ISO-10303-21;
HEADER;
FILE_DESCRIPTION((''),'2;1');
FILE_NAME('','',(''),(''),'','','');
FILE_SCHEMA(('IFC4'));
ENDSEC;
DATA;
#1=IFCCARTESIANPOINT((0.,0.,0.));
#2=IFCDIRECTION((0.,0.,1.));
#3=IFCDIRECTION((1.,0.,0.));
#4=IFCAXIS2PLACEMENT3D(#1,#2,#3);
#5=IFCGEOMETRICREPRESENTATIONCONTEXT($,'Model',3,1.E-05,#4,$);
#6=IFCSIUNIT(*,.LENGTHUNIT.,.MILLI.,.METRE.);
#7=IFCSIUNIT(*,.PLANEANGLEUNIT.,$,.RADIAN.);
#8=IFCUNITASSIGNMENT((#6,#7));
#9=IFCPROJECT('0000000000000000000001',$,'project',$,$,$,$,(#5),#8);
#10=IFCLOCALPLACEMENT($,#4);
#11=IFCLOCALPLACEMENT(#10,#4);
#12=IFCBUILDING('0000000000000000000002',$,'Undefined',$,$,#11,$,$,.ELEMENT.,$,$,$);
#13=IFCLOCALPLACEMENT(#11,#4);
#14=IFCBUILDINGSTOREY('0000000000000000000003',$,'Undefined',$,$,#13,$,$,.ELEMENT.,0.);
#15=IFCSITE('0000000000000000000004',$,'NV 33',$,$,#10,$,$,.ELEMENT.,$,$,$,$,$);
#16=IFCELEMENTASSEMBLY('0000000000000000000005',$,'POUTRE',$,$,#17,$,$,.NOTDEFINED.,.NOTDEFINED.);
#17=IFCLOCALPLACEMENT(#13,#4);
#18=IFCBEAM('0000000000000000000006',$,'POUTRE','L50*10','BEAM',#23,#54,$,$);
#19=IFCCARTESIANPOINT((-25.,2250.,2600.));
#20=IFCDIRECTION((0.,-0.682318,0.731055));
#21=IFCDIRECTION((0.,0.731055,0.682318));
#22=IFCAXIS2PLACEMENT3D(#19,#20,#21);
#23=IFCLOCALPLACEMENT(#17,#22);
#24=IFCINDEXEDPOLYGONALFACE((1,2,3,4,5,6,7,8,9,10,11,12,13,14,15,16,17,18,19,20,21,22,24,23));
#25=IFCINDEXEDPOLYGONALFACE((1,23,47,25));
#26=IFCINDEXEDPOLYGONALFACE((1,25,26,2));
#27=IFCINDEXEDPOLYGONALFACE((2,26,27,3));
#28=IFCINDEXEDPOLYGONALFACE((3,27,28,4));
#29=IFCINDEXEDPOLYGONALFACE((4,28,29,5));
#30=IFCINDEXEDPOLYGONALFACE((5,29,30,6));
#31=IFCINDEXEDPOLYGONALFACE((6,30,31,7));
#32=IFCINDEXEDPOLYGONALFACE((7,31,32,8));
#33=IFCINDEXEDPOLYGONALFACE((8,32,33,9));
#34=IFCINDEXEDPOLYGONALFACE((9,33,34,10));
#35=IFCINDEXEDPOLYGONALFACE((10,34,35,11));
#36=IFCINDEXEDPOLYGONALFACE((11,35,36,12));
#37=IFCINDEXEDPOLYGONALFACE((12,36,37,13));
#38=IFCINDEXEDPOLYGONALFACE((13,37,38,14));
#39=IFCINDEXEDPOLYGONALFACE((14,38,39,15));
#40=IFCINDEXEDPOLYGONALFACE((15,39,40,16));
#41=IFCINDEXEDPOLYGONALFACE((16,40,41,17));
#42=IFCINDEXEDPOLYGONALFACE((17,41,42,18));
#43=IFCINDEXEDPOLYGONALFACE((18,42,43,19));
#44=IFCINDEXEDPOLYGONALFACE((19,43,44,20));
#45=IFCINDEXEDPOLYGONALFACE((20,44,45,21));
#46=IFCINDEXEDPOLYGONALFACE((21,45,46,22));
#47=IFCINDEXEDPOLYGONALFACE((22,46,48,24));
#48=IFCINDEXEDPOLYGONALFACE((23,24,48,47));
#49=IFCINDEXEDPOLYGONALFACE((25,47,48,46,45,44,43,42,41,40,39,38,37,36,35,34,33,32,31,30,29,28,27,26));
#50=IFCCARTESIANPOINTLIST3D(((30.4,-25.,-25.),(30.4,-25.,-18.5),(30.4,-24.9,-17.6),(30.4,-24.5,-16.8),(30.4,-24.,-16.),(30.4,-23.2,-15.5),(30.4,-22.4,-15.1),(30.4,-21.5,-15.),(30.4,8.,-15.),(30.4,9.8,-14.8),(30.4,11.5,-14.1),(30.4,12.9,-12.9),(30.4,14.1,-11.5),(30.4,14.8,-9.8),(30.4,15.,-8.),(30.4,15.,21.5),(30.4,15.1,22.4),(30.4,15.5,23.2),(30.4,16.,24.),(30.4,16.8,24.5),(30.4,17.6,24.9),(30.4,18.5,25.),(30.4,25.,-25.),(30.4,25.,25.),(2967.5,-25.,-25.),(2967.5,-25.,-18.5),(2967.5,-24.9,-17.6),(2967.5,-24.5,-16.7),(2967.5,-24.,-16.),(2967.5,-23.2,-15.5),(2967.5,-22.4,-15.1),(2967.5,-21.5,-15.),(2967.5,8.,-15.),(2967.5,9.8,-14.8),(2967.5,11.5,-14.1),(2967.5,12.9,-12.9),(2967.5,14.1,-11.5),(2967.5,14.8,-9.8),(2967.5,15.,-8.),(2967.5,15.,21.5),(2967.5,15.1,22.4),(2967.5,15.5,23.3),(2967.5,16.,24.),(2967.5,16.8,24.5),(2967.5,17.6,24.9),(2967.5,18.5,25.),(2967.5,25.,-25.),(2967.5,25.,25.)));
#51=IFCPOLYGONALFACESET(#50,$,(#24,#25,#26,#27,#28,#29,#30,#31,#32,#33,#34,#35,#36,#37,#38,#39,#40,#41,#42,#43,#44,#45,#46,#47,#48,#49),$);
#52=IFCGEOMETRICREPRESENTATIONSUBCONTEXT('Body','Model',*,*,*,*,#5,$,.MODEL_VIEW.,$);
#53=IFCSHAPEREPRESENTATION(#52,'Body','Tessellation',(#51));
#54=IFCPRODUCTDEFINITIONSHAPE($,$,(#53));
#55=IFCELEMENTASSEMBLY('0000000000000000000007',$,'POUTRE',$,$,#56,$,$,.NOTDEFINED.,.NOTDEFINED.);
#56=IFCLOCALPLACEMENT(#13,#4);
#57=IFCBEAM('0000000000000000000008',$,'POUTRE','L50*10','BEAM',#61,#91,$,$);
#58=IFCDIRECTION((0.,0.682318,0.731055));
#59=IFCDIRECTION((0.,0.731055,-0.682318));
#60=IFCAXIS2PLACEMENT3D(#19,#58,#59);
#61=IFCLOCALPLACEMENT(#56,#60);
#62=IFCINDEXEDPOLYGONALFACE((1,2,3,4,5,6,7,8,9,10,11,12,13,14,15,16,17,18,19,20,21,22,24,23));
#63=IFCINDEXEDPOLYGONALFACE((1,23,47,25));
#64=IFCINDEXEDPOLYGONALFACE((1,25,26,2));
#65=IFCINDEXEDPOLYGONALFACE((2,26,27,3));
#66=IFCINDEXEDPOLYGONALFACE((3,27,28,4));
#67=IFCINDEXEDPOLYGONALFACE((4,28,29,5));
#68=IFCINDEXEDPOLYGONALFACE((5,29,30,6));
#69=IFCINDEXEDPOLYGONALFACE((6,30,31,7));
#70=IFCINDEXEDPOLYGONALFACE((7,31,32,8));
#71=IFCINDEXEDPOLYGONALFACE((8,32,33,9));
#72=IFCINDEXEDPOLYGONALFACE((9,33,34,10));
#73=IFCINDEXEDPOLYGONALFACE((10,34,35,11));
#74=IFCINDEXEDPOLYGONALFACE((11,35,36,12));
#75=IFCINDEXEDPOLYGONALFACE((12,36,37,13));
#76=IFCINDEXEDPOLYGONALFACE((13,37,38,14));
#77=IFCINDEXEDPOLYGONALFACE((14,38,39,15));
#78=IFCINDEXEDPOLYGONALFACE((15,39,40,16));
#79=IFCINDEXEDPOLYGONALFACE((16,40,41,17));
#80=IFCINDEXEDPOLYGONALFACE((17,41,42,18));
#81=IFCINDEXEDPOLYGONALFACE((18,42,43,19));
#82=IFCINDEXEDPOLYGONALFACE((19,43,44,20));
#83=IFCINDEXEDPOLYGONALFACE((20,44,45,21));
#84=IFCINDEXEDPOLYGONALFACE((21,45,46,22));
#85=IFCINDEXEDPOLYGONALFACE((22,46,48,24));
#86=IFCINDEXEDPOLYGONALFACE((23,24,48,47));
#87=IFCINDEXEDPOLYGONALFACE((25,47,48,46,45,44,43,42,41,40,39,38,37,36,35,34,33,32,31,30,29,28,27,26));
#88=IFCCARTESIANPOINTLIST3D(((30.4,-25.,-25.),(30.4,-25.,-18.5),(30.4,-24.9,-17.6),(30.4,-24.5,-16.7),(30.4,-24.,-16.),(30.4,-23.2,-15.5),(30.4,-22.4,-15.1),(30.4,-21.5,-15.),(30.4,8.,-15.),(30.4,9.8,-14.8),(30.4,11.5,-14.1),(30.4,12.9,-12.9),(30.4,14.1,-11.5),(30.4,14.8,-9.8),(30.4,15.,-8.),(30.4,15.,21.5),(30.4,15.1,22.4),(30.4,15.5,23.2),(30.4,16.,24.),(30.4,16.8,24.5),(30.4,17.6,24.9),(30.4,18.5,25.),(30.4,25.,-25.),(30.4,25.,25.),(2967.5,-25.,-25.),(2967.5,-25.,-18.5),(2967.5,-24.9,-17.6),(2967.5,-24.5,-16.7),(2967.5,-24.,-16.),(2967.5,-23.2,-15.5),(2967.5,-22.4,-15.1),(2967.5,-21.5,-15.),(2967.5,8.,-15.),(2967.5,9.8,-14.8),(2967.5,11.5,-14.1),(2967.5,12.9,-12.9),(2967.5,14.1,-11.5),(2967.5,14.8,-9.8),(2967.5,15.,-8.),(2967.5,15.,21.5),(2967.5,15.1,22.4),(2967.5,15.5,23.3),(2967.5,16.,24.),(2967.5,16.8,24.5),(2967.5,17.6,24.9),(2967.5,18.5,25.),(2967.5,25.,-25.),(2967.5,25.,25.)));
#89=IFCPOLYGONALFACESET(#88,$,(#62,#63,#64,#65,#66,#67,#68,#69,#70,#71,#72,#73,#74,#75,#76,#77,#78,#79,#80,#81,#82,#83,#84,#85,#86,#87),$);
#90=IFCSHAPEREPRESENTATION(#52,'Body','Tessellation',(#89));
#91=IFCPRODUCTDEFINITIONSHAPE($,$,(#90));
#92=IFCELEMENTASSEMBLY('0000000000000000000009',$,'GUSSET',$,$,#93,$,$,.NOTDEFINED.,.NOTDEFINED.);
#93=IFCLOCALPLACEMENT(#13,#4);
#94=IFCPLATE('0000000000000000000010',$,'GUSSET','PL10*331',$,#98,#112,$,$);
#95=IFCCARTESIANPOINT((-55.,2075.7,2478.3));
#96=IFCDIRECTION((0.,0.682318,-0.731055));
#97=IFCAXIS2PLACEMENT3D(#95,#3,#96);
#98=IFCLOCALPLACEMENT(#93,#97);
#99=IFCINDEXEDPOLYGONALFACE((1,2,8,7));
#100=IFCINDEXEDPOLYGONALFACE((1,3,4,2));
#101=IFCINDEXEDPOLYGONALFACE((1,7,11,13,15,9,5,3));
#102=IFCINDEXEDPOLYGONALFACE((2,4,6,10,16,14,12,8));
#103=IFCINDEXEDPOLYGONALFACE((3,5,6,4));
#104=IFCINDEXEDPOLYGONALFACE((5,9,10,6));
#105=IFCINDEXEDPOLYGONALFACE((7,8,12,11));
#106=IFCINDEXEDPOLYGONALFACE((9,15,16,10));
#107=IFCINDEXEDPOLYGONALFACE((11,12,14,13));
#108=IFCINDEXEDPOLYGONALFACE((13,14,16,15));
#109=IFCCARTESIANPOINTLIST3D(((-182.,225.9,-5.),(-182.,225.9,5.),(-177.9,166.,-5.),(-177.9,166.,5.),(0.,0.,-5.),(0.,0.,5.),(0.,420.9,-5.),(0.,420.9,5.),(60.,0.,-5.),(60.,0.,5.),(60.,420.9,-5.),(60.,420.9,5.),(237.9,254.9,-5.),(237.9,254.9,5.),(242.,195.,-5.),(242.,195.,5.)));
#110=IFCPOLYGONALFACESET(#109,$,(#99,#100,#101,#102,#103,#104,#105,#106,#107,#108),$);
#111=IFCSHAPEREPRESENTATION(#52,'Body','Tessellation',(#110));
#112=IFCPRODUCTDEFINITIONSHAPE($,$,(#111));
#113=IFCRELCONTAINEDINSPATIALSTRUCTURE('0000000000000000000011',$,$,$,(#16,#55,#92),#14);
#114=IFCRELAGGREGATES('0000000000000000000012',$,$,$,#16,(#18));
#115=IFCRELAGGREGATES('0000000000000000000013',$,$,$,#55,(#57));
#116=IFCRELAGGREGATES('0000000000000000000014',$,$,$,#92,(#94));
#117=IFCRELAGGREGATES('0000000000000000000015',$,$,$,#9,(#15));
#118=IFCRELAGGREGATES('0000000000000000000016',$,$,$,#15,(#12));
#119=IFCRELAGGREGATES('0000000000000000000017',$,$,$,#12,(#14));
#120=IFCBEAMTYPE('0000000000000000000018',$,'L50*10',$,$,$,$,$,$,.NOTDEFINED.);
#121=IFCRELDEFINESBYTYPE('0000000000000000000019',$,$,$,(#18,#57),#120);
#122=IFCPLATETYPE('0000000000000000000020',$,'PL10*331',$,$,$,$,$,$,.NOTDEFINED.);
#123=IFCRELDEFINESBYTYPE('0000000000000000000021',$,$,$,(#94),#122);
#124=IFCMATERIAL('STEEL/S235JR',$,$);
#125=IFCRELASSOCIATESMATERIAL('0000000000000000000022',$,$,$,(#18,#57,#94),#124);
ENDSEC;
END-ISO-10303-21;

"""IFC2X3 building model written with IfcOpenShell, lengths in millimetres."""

from ifc_helpers import new_model, si_unit, frame, origin_with_axes, origin_2d_with_axis, place, context, subcontext, project, spatial, polyline, l_section, outline, extrude, clip, halfspace, material, type_object, element, aggregate, save


model = new_model("IFC2X3")

# Units and contexts
model_context = context("Model", 3, precision=1e-05, world=origin_with_axes())
body_context = subcontext(model_context, "Body", "Model", "MODEL_VIEW")
ifc_project = project(units=[si_unit("LENGTHUNIT", "METRE", prefix="MILLI"), si_unit("PLANEANGLEUNIT", "RADIAN")], contexts=[model_context])

# Site, building, storey
site_placement = place(None, origin_with_axes())
site = spatial("IfcSite", under=ifc_project, at=site_placement, Name="NV 33", CompositionType="ELEMENT")
building_placement = place(site_placement, origin_with_axes())
building = spatial("IfcBuilding", under=site, at=building_placement, Name="Undefined", CompositionType="ELEMENT")
storey_placement = place(building_placement, origin_with_axes())
storey = spatial("IfcBuildingStorey", under=building, at=storey_placement, Name="Undefined", CompositionType="ELEMENT", Elevation=0.0)

# Element assemblies, beams
assembly_1_placement = place(storey_placement, origin_with_axes())
assembly_1 = element("IfcElementAssembly", 1, at=assembly_1_placement, inside=storey, Name="POUTRE", AssemblyPlace="NOTDEFINED", PredefinedType="NOTDEFINED")
ifc_material_1 = material(Name="STEEL/S235JR")
beam_type_1 = type_object("IfcBeamType", Name="L50*10", PredefinedType="NOTDEFINED")
beam_1_placement = place(assembly_1_placement, frame((-25.0, 2250.0, 2600.0), z_axis=(0.0, -0.682318, 0.731055), x_axis=(0.0, 0.731055, 0.682318)))
beam_1 = element("IfcBeam", 2, at=beam_1_placement, type_object=beam_type_1, material=ifc_material_1, Name="POUTRE", Description="L50*10", ObjectType="BEAM", context=body_context, shape_type="Clipping", body=[
    clip(clip(extrude(l_section(Depth=50.0, Width=50.0, Thickness=10.0, FilletRadius=7.0, EdgeRadius=3.5, at=origin_2d_with_axis()), frame((3077.7, 0.0, 0.0), z_axis=(-1.0, 0.0, 0.0), x_axis=(0.0, -1.0, 0.0)), (0.0, 0.0, 1.0), 3097.7), halfspace(frame((2967.5, 31.0, 0.0), z_axis=(-1.0, 0.0, 0.0), x_axis=(0.0, 0.0, 1.0)), True)), halfspace(frame((30.4, 0.0, 25.0), z_axis=(1.0, 0.0, 0.0), x_axis=(0.0, 1.0, 0.0)), True)),
])
assembly_2_placement = place(storey_placement, origin_with_axes())
assembly_2 = element("IfcElementAssembly", 3, at=assembly_2_placement, inside=storey, Name="POUTRE", AssemblyPlace="NOTDEFINED", PredefinedType="NOTDEFINED")
beam_2_placement = place(assembly_2_placement, frame((-25.0, 2250.0, 2600.0), z_axis=(0.0, 0.682318, 0.731055), x_axis=(0.0, 0.731055, -0.682318)))
beam_2 = element("IfcBeam", 4, at=beam_2_placement, type_object=beam_type_1, material=ifc_material_1, Name="POUTRE", Description="L50*10", ObjectType="BEAM", context=body_context, shape_type="Clipping", body=[
    clip(clip(extrude(l_section(Depth=50.0, Width=50.0, Thickness=10.0, FilletRadius=7.0, EdgeRadius=3.5, at=origin_2d_with_axis()), frame((3077.7, 0.0, 0.0), z_axis=(-1.0, 0.0, 0.0), x_axis=(0.0, -1.0, 0.0)), (0.0, 0.0, 1.0), 3097.7), halfspace(frame((2967.5, 31.0, 0.0), z_axis=(-1.0, 0.0, 0.0), x_axis=(0.0, 0.0, 1.0)), True)), halfspace(frame((30.4, 0.0, 25.0), z_axis=(1.0, 0.0, 0.0), x_axis=(0.0, 1.0, 0.0)), True)),
])

# Element assembly, plate
assembly_3_placement = place(storey_placement, origin_with_axes())
assembly_3 = element("IfcElementAssembly", 5, at=assembly_3_placement, inside=storey, Name="GUSSET", AssemblyPlace="NOTDEFINED", PredefinedType="NOTDEFINED")
plate_type_1 = type_object("IfcPlateType", Name="PL10*331", PredefinedType="NOTDEFINED")
plate_1_placement = place(assembly_3_placement, frame((-55.0, 2075.7, 2478.3), z_axis=(1.0, 0.0, 0.0), x_axis=(0.0, 0.682318, -0.731055)))
plate_1 = element("IfcPlate", 6, at=plate_1_placement, type_object=plate_type_1, material=ifc_material_1, Name="GUSSET", Description="PL10*331", context=body_context, shape_type="SweptSolid", body=[
    extrude(outline(polyline([(0.0, 0.0), (60.0, 0.0), (242.0, 195.0), (237.9, 254.9), (60.0, 420.9), (0.0, 420.9), (-182.0, 225.9), (-177.9, 166.0), (0.0, 0.0)])), frame((0.0, 0.0, -5.0), z_axis=(0.0, 0.0, 1.0), x_axis=(1.0, 0.0, 0.0)), (0.0, 0.0, 1.0), 10.0),
])

aggregate(assembly_1, [beam_1])
aggregate(assembly_2, [beam_2])

aggregate(assembly_3, [plate_1])

save(model, "model.ifc")
